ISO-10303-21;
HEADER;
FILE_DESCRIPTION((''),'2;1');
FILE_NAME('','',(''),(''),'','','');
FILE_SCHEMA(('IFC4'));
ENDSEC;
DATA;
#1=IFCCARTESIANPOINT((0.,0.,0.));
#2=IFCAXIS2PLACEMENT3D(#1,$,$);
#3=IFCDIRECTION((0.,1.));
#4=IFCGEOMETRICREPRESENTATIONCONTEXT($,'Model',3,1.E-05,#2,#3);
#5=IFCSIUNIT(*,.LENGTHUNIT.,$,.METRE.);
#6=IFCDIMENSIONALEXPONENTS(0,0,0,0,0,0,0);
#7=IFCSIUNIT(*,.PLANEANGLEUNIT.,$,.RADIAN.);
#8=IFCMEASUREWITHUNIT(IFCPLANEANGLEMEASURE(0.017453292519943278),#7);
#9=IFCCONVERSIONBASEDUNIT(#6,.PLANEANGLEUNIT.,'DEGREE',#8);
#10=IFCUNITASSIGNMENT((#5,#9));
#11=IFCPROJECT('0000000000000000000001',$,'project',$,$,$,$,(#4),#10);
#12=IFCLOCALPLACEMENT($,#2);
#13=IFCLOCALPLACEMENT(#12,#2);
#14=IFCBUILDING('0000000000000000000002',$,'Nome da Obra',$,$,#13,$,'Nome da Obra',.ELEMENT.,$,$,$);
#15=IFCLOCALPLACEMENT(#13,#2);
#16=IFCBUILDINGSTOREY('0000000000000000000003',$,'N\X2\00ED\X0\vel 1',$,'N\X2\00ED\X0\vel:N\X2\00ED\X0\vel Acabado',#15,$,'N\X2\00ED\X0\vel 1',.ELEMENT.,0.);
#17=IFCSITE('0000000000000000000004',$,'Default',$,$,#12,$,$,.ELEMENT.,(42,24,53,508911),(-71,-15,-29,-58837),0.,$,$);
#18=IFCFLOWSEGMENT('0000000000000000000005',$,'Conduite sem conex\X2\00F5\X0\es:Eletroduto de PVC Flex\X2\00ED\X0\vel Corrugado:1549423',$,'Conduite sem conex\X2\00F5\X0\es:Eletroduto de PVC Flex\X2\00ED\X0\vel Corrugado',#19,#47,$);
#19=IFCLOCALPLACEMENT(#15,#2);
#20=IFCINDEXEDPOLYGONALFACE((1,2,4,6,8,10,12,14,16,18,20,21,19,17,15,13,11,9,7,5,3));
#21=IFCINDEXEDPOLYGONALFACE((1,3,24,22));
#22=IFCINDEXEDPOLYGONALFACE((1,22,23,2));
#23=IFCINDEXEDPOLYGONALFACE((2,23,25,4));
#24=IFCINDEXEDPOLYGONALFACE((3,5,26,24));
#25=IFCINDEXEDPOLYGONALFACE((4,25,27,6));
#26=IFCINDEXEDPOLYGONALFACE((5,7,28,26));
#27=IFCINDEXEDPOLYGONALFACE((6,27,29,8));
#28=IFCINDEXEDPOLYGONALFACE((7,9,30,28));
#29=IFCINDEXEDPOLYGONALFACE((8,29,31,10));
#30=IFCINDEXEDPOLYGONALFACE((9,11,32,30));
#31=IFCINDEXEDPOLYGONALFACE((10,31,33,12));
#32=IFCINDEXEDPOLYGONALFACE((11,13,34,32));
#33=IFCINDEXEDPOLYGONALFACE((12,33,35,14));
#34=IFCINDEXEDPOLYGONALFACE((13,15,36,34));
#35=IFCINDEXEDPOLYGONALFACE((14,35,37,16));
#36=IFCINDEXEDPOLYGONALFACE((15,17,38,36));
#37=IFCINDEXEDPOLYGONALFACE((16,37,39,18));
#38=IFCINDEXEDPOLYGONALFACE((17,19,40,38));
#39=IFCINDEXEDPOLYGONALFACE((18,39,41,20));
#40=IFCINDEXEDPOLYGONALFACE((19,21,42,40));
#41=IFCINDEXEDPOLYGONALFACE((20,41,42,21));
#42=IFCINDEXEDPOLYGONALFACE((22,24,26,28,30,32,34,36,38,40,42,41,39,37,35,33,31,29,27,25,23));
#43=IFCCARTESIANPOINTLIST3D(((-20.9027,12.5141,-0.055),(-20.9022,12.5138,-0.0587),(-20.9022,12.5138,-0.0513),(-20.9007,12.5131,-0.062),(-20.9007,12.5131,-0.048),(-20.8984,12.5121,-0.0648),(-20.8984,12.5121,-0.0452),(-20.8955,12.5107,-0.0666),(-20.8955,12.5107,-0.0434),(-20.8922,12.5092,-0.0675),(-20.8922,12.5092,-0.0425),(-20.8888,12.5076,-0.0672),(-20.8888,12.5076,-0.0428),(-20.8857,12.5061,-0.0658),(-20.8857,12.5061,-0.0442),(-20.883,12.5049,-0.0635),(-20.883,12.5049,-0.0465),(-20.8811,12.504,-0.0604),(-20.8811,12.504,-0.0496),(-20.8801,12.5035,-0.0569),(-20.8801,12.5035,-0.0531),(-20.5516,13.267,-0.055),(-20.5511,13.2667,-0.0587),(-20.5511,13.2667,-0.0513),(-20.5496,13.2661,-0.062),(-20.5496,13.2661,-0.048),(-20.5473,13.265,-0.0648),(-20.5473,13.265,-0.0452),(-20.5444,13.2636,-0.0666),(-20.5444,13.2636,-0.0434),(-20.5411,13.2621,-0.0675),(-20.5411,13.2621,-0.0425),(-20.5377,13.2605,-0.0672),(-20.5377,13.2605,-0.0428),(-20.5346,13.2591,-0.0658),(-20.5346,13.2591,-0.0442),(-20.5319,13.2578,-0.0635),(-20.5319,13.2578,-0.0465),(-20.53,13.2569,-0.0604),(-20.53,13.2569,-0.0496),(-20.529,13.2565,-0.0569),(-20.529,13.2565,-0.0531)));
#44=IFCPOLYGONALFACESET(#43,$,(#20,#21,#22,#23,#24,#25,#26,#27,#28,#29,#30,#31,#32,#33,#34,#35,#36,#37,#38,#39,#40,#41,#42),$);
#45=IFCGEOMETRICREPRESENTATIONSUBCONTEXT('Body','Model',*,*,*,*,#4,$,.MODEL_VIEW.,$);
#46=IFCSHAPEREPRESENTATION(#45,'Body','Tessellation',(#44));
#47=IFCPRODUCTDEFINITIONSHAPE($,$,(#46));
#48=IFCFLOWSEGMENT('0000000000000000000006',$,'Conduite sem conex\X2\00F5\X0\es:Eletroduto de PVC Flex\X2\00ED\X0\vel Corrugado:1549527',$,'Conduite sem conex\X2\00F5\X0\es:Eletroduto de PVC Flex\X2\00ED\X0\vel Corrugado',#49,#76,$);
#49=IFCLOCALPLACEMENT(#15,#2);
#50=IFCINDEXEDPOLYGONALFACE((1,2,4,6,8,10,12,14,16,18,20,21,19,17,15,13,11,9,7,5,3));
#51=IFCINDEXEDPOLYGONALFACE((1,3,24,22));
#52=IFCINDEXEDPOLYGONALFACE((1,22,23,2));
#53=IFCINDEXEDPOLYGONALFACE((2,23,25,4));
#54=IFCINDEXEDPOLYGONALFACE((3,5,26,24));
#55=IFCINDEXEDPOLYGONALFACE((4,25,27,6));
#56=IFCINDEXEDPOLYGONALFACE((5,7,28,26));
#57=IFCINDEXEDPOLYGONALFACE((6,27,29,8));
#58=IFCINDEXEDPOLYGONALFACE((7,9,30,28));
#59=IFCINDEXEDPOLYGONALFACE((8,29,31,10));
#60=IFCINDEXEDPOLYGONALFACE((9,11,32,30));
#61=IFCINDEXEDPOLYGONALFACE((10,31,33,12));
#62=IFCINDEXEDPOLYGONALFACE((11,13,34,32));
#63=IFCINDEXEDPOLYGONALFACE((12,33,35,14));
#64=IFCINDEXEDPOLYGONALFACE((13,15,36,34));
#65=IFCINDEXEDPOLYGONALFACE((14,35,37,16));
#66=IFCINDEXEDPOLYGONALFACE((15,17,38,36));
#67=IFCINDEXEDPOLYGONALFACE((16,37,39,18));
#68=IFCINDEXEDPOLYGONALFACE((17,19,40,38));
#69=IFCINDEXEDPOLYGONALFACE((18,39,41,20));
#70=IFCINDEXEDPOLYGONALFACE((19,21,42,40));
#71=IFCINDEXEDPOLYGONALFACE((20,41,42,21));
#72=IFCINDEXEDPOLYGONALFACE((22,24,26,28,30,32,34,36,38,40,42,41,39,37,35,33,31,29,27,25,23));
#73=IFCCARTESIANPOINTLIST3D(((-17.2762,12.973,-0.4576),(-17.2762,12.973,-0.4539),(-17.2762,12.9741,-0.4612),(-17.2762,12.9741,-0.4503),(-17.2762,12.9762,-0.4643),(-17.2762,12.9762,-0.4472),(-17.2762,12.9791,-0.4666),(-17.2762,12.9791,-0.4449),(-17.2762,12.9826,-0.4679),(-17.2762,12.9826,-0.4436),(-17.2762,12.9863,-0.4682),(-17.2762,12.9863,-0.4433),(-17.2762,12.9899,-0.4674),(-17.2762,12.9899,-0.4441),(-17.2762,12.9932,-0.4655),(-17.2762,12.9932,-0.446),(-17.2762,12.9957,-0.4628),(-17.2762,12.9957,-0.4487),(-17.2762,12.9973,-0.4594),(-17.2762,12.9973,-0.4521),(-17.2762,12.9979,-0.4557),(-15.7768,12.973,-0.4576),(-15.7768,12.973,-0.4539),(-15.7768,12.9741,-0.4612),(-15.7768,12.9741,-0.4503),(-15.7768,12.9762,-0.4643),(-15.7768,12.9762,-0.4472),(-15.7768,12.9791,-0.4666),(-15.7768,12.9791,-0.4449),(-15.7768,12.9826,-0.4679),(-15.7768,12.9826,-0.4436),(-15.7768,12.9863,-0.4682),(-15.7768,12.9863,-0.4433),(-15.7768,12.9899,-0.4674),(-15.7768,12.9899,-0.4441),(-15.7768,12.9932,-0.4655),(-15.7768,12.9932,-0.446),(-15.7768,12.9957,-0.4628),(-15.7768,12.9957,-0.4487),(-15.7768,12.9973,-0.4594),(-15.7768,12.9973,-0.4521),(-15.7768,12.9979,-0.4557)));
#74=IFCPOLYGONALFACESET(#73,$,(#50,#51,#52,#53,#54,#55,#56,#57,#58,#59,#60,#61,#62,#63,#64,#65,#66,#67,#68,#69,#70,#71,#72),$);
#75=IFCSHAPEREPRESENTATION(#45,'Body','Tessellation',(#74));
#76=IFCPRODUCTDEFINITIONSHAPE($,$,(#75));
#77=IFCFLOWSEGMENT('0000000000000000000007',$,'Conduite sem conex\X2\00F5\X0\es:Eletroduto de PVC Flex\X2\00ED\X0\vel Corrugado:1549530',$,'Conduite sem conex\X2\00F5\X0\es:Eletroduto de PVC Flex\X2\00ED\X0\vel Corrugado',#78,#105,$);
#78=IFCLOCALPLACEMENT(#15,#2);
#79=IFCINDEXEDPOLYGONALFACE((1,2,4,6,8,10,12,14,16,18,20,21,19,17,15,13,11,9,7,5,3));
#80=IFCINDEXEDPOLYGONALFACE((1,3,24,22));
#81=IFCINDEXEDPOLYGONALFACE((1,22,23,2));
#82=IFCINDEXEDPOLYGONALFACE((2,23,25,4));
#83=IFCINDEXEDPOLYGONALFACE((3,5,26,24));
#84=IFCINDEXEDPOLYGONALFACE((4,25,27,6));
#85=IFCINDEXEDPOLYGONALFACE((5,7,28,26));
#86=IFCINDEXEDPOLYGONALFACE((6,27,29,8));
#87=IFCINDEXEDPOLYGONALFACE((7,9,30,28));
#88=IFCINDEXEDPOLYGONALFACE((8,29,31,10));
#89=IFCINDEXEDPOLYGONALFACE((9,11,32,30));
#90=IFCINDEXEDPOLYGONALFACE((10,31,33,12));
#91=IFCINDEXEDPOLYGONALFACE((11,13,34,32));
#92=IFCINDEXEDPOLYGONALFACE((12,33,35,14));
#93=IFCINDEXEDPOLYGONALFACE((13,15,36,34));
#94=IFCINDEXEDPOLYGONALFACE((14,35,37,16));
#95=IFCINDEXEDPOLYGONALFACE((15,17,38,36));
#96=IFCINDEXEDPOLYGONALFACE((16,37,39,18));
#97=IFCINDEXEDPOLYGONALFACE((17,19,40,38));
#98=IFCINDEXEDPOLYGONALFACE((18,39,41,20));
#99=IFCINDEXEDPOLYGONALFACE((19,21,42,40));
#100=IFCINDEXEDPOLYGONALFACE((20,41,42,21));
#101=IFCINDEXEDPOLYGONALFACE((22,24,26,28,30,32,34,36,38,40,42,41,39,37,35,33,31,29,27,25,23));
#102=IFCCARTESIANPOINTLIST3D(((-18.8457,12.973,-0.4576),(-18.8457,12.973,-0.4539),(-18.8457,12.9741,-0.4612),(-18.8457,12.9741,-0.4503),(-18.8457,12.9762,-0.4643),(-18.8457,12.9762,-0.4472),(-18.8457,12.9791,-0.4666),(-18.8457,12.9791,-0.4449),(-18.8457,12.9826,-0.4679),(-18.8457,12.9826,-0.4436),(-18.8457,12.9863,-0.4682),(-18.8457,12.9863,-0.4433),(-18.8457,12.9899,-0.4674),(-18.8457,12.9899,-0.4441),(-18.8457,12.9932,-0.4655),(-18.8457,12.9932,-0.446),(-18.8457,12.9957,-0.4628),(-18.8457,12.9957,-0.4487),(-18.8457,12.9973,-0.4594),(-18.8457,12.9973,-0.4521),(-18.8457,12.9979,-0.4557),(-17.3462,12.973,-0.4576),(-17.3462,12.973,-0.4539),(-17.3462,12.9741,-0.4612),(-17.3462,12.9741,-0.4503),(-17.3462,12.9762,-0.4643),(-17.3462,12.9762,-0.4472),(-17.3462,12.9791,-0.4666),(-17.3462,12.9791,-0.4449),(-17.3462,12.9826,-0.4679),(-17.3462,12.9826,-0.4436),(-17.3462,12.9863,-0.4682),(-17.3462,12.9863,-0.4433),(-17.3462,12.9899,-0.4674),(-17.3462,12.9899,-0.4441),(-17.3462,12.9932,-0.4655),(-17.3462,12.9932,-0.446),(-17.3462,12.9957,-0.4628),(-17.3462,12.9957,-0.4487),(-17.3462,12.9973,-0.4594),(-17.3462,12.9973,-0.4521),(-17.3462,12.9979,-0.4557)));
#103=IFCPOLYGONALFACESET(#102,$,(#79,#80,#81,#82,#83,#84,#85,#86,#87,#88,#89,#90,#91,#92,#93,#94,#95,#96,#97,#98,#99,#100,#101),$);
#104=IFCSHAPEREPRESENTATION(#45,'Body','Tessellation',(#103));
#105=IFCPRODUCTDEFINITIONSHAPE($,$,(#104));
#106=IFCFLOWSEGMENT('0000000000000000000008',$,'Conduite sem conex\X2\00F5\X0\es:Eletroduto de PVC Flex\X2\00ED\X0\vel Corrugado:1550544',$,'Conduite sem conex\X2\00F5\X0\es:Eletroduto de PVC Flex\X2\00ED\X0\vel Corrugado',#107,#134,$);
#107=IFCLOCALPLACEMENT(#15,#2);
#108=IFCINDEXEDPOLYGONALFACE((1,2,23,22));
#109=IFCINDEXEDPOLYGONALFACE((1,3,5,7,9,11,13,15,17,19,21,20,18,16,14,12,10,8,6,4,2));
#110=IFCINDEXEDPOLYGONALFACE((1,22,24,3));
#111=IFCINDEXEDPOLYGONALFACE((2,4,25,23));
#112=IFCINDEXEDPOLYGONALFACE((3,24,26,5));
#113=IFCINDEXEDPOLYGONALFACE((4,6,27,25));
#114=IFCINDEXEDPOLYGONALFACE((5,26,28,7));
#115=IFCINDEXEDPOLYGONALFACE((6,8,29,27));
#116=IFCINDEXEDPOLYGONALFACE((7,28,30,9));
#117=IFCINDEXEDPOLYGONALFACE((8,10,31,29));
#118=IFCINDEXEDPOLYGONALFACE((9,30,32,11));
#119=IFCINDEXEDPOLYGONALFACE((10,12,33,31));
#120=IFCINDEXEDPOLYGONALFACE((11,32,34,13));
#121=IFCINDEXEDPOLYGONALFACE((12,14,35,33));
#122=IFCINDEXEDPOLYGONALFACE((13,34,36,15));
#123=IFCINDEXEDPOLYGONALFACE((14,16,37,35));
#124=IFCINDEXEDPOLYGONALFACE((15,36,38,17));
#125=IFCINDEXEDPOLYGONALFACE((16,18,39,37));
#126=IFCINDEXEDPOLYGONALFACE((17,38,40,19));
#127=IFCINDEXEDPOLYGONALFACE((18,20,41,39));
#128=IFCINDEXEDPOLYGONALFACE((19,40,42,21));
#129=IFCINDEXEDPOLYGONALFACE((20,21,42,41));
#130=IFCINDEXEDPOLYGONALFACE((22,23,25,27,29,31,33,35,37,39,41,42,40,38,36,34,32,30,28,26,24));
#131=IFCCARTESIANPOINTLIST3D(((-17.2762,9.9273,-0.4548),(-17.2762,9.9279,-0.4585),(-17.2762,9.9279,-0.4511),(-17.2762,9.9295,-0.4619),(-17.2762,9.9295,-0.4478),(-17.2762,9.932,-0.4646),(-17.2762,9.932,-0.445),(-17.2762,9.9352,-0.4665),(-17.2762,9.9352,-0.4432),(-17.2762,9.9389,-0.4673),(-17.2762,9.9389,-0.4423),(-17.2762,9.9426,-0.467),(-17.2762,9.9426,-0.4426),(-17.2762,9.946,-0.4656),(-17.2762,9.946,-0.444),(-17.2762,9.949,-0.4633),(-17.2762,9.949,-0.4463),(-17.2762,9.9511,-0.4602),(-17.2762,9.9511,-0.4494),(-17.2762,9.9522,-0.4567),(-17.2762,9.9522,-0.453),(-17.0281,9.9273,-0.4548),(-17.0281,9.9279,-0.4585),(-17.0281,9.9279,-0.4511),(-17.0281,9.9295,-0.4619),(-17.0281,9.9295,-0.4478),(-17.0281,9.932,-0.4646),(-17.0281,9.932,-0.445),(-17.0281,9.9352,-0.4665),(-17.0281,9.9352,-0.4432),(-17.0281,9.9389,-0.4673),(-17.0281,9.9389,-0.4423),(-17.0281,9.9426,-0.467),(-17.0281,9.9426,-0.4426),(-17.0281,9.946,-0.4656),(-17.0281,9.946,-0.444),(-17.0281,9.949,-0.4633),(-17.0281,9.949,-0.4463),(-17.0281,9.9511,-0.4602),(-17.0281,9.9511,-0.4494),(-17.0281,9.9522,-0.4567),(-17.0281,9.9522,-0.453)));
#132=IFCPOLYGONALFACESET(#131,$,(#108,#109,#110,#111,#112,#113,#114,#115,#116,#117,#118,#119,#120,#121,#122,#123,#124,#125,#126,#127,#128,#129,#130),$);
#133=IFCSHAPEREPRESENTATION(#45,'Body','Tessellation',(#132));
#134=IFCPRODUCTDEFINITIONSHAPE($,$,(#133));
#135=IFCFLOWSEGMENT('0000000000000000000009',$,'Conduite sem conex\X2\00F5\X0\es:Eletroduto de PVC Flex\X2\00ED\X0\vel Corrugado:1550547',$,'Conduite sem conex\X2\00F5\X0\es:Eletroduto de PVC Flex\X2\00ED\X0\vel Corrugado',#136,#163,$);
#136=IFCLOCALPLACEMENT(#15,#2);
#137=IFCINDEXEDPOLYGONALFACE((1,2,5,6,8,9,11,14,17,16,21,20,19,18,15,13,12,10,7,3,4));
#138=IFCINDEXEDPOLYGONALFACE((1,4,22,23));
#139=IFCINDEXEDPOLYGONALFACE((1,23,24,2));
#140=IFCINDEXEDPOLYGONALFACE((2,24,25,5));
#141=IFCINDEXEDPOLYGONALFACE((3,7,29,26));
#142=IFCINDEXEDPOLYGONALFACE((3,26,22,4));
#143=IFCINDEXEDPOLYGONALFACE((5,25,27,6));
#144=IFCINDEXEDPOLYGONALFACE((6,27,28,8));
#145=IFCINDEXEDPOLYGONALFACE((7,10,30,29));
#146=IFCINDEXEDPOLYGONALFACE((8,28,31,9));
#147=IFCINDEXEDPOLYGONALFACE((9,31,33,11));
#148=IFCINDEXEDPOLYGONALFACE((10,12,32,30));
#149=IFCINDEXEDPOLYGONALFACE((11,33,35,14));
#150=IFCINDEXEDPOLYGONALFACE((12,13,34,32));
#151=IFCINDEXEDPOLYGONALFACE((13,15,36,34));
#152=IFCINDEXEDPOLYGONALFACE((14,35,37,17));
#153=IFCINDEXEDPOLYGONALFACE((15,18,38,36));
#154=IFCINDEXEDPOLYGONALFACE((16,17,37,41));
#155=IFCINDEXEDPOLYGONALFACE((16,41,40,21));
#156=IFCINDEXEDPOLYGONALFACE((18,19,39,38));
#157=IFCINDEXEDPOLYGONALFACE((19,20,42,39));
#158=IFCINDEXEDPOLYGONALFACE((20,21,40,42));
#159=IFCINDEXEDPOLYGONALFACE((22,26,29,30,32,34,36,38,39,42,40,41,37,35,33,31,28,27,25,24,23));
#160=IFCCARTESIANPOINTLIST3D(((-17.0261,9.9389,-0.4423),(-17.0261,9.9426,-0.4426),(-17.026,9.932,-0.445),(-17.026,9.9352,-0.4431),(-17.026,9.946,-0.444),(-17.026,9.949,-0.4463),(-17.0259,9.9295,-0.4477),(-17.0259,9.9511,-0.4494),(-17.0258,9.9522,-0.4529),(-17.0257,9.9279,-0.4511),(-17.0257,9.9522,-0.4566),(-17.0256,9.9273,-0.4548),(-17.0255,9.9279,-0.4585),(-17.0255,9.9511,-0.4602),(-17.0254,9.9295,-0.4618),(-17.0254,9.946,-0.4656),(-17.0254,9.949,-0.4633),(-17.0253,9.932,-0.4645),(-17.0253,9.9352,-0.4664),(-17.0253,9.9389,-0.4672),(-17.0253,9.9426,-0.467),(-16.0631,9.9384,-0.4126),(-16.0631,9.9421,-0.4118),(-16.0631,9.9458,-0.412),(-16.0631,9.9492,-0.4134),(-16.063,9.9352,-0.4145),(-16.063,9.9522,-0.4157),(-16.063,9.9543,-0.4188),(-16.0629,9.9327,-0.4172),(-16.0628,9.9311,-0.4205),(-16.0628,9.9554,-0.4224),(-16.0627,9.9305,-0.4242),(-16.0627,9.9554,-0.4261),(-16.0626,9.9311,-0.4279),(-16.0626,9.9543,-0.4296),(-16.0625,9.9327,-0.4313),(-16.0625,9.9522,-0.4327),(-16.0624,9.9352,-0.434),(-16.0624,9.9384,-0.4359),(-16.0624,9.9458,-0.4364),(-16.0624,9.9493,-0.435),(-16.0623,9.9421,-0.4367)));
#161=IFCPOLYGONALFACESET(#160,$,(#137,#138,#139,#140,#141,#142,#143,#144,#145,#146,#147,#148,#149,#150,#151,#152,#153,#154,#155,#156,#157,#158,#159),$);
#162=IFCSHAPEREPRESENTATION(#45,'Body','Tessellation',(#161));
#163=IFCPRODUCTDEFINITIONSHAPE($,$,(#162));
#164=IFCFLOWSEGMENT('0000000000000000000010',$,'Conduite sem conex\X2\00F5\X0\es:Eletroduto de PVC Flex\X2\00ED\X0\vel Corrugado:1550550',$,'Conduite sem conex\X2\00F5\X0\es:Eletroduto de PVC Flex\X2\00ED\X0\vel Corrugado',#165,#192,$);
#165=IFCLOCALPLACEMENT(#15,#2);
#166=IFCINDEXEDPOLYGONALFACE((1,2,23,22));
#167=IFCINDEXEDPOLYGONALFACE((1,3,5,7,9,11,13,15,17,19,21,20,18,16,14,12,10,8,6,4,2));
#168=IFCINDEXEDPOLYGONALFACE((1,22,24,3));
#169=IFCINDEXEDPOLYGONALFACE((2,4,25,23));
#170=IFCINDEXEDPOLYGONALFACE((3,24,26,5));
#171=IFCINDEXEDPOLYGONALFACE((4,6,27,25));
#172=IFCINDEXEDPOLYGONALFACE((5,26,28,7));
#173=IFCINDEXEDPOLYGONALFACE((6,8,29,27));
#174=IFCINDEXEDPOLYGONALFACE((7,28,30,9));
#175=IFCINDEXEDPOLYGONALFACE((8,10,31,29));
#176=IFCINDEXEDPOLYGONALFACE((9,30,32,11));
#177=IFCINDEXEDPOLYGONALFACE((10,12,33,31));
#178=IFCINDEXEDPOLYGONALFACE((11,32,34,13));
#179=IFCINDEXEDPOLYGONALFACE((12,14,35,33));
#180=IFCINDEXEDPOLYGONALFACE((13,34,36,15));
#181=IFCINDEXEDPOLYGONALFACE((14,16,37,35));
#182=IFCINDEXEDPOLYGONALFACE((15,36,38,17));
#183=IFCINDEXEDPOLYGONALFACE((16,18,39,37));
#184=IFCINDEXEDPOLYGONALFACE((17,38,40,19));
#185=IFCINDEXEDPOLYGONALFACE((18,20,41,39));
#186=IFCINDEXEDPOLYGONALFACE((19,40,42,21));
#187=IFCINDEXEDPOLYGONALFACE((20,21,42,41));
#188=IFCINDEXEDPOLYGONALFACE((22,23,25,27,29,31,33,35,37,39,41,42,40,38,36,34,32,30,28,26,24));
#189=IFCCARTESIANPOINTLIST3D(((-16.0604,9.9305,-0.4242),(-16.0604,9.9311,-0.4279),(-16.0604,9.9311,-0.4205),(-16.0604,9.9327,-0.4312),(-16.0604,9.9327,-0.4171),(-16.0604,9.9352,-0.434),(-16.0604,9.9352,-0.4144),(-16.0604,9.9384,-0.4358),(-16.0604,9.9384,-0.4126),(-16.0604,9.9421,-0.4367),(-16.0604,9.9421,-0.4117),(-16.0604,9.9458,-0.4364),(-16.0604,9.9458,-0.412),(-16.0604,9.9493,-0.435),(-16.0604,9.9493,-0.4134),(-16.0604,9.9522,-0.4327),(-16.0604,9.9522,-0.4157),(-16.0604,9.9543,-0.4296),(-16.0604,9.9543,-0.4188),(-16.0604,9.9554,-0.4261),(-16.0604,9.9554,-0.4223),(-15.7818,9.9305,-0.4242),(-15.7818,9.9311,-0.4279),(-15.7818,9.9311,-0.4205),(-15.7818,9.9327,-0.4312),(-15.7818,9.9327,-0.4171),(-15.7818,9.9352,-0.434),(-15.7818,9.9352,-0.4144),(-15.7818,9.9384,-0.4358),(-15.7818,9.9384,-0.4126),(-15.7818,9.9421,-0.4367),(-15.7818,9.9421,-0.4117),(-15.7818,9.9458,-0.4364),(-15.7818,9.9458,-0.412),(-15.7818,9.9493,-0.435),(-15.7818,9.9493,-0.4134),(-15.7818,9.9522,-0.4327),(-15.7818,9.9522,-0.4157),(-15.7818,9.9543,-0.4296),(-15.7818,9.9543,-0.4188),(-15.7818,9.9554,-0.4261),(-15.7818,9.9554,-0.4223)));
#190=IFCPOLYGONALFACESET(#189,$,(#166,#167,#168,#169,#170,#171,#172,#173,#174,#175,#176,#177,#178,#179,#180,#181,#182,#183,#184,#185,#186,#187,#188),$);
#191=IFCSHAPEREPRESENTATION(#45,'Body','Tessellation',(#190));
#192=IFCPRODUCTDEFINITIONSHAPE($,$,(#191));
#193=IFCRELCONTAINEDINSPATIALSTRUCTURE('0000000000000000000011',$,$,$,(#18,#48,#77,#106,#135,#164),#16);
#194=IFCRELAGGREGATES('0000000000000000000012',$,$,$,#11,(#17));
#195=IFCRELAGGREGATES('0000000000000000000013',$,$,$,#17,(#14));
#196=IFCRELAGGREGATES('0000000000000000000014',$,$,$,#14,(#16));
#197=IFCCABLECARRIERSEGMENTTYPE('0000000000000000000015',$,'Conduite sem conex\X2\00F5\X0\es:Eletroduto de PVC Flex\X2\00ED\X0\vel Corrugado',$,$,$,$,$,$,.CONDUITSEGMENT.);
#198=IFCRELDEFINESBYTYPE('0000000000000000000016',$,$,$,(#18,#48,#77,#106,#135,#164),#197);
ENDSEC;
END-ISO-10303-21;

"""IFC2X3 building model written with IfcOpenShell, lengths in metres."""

from ifc_helpers import new_model, entity, si_unit, converted_unit, direction, frame, frame_2d, origin, origin_2d_with_axis, place, context, subcontext, project, spatial, circle, extrude, type_object, element, save


model = new_model("IFC2X3")

# Units and contexts
model_context = context("Model", 3, precision=1e-05, world=origin(), true_north=direction((0.0, 1.0)))
body_context = subcontext(model_context, "Body", "Model", "MODEL_VIEW")
ifc_project = project(units=[si_unit("LENGTHUNIT", "METRE"), converted_unit("PLANEANGLEUNIT", "DEGREE", entity("IfcPlaneAngleMeasure", 0.017453292519943278), si_unit("PLANEANGLEUNIT", "RADIAN"), dimensions=[0, 0, 0, 0, 0, 0, 0])], contexts=[model_context])

# Site, building, storey
site_placement = place(None, origin())
site = spatial("IfcSite", under=ifc_project, at=site_placement, Name="Default", CompositionType="ELEMENT", RefLatitude=(42, 24, 53, 508911), RefLongitude=(-71, -15, -29, -58837), RefElevation=0.0)
building_placement = place(site_placement, origin())
building = spatial("IfcBuilding", under=site, at=building_placement, Name="Nome da Obra", LongName="Nome da Obra", CompositionType="ELEMENT")
storey_placement = place(building_placement, origin())
storey = spatial("IfcBuildingStorey", under=building, at=storey_placement, Name="Nível 1", ObjectType="Nível:Nível Acabado", LongName="Nível 1", CompositionType="ELEMENT", Elevation=0.0)

# Flow segments
cable_carrier_segment_type = type_object("IfcCableCarrierSegmentType", Name="Conduite sem conexões:Eletroduto de PVC Flexível Corrugado", PredefinedType="CONDUITSEGMENT")
flow_segment_1_placement = place(storey_placement, origin())
element("IfcFlowSegment", 1, at=flow_segment_1_placement, inside=storey, type_object=cable_carrier_segment_type, Name="Conduite sem conexões:Eletroduto de PVC Flexível Corrugado:1549423", ObjectType="Conduite sem conexões:Eletroduto de PVC Flexível Corrugado", context=body_context, shape_type="SweptSolid", body=[
    extrude(circle(Radius=0.0125, at=frame_2d((0.0, 0.0), x_axis=(1.0, 0.0))), frame((-20.8913, 12.5088, -0.055), z_axis=(0.422618, 0.906308, 0.0), x_axis=(-0.906308, 0.422618, 0.0)), (0.0, 0.0, 1.0), 0.8308),
])
flow_segment_2_placement = place(storey_placement, origin())
element("IfcFlowSegment", 2, at=flow_segment_2_placement, inside=storey, type_object=cable_carrier_segment_type, Name="Conduite sem conexões:Eletroduto de PVC Flexível Corrugado:1549527", ObjectType="Conduite sem conexões:Eletroduto de PVC Flexível Corrugado", context=body_context, shape_type="SweptSolid", body=[
    extrude(circle(Radius=0.0125, at=frame_2d((0.0, 0.0), x_axis=(1.0, 0.0))), frame((-17.2762, 12.9854, -0.4557), z_axis=(1.0, 0.0, 0.0), x_axis=(0.0, 1.0, 0.0)), (0.0, 0.0, 1.0), 1.4995),
])
flow_segment_3_placement = place(storey_placement, origin())
element("IfcFlowSegment", 3, at=flow_segment_3_placement, inside=storey, type_object=cable_carrier_segment_type, Name="Conduite sem conexões:Eletroduto de PVC Flexível Corrugado:1549530", ObjectType="Conduite sem conexões:Eletroduto de PVC Flexível Corrugado", context=body_context, shape_type="SweptSolid", body=[
    extrude(circle(Radius=0.0125, at=frame_2d((0.0, 0.0), x_axis=(1.0, 0.0))), frame((-18.8457, 12.9854, -0.4557), z_axis=(1.0, 0.0, 0.0), x_axis=(0.0, 1.0, 0.0)), (0.0, 0.0, 1.0), 1.4995),
])
flow_segment_4_placement = place(storey_placement, origin())
element("IfcFlowSegment", 4, at=flow_segment_4_placement, inside=storey, type_object=cable_carrier_segment_type, Name="Conduite sem conexões:Eletroduto de PVC Flexível Corrugado:1550544", ObjectType="Conduite sem conexões:Eletroduto de PVC Flexível Corrugado", context=body_context, shape_type="SweptSolid", body=[
    extrude(circle(Radius=0.0125, at=origin_2d_with_axis()), frame((-17.2762, 9.9398, -0.4548), z_axis=(1.0, 0.0, 0.0), x_axis=(0.0, -1.0, 0.0)), (0.0, 0.0, 1.0), 0.2482),
])
flow_segment_5_placement = place(storey_placement, origin())
element("IfcFlowSegment", 5, at=flow_segment_5_placement, inside=storey, type_object=cable_carrier_segment_type, Name="Conduite sem conexões:Eletroduto de PVC Flexível Corrugado:1550547", ObjectType="Conduite sem conexões:Eletroduto de PVC Flexível Corrugado", context=body_context, shape_type="SweptSolid", body=[
    extrude(circle(Radius=0.0125, at=frame_2d((0.0, 0.0), x_axis=(1.0, 0.0))), frame((-17.0257, 9.9398, -0.4548), z_axis=(0.999492, 0.003323, 0.031708), x_axis=(0.003325, -0.999994, 0.0)), (0.0, 0.0, 1.0), 0.9634),
])
flow_segment_6_placement = place(storey_placement, origin())
element("IfcFlowSegment", 6, at=flow_segment_6_placement, inside=storey, type_object=cable_carrier_segment_type, Name="Conduite sem conexões:Eletroduto de PVC Flexível Corrugado:1550550", ObjectType="Conduite sem conexões:Eletroduto de PVC Flexível Corrugado", context=body_context, shape_type="SweptSolid", body=[
    extrude(circle(Radius=0.0125, at=origin_2d_with_axis()), frame((-16.0604, 9.943, -0.4242), z_axis=(1.0, 0.0, 0.0), x_axis=(0.0, -1.0, 0.0)), (0.0, 0.0, 1.0), 0.2786),
])

save(model, "model.ifc")
